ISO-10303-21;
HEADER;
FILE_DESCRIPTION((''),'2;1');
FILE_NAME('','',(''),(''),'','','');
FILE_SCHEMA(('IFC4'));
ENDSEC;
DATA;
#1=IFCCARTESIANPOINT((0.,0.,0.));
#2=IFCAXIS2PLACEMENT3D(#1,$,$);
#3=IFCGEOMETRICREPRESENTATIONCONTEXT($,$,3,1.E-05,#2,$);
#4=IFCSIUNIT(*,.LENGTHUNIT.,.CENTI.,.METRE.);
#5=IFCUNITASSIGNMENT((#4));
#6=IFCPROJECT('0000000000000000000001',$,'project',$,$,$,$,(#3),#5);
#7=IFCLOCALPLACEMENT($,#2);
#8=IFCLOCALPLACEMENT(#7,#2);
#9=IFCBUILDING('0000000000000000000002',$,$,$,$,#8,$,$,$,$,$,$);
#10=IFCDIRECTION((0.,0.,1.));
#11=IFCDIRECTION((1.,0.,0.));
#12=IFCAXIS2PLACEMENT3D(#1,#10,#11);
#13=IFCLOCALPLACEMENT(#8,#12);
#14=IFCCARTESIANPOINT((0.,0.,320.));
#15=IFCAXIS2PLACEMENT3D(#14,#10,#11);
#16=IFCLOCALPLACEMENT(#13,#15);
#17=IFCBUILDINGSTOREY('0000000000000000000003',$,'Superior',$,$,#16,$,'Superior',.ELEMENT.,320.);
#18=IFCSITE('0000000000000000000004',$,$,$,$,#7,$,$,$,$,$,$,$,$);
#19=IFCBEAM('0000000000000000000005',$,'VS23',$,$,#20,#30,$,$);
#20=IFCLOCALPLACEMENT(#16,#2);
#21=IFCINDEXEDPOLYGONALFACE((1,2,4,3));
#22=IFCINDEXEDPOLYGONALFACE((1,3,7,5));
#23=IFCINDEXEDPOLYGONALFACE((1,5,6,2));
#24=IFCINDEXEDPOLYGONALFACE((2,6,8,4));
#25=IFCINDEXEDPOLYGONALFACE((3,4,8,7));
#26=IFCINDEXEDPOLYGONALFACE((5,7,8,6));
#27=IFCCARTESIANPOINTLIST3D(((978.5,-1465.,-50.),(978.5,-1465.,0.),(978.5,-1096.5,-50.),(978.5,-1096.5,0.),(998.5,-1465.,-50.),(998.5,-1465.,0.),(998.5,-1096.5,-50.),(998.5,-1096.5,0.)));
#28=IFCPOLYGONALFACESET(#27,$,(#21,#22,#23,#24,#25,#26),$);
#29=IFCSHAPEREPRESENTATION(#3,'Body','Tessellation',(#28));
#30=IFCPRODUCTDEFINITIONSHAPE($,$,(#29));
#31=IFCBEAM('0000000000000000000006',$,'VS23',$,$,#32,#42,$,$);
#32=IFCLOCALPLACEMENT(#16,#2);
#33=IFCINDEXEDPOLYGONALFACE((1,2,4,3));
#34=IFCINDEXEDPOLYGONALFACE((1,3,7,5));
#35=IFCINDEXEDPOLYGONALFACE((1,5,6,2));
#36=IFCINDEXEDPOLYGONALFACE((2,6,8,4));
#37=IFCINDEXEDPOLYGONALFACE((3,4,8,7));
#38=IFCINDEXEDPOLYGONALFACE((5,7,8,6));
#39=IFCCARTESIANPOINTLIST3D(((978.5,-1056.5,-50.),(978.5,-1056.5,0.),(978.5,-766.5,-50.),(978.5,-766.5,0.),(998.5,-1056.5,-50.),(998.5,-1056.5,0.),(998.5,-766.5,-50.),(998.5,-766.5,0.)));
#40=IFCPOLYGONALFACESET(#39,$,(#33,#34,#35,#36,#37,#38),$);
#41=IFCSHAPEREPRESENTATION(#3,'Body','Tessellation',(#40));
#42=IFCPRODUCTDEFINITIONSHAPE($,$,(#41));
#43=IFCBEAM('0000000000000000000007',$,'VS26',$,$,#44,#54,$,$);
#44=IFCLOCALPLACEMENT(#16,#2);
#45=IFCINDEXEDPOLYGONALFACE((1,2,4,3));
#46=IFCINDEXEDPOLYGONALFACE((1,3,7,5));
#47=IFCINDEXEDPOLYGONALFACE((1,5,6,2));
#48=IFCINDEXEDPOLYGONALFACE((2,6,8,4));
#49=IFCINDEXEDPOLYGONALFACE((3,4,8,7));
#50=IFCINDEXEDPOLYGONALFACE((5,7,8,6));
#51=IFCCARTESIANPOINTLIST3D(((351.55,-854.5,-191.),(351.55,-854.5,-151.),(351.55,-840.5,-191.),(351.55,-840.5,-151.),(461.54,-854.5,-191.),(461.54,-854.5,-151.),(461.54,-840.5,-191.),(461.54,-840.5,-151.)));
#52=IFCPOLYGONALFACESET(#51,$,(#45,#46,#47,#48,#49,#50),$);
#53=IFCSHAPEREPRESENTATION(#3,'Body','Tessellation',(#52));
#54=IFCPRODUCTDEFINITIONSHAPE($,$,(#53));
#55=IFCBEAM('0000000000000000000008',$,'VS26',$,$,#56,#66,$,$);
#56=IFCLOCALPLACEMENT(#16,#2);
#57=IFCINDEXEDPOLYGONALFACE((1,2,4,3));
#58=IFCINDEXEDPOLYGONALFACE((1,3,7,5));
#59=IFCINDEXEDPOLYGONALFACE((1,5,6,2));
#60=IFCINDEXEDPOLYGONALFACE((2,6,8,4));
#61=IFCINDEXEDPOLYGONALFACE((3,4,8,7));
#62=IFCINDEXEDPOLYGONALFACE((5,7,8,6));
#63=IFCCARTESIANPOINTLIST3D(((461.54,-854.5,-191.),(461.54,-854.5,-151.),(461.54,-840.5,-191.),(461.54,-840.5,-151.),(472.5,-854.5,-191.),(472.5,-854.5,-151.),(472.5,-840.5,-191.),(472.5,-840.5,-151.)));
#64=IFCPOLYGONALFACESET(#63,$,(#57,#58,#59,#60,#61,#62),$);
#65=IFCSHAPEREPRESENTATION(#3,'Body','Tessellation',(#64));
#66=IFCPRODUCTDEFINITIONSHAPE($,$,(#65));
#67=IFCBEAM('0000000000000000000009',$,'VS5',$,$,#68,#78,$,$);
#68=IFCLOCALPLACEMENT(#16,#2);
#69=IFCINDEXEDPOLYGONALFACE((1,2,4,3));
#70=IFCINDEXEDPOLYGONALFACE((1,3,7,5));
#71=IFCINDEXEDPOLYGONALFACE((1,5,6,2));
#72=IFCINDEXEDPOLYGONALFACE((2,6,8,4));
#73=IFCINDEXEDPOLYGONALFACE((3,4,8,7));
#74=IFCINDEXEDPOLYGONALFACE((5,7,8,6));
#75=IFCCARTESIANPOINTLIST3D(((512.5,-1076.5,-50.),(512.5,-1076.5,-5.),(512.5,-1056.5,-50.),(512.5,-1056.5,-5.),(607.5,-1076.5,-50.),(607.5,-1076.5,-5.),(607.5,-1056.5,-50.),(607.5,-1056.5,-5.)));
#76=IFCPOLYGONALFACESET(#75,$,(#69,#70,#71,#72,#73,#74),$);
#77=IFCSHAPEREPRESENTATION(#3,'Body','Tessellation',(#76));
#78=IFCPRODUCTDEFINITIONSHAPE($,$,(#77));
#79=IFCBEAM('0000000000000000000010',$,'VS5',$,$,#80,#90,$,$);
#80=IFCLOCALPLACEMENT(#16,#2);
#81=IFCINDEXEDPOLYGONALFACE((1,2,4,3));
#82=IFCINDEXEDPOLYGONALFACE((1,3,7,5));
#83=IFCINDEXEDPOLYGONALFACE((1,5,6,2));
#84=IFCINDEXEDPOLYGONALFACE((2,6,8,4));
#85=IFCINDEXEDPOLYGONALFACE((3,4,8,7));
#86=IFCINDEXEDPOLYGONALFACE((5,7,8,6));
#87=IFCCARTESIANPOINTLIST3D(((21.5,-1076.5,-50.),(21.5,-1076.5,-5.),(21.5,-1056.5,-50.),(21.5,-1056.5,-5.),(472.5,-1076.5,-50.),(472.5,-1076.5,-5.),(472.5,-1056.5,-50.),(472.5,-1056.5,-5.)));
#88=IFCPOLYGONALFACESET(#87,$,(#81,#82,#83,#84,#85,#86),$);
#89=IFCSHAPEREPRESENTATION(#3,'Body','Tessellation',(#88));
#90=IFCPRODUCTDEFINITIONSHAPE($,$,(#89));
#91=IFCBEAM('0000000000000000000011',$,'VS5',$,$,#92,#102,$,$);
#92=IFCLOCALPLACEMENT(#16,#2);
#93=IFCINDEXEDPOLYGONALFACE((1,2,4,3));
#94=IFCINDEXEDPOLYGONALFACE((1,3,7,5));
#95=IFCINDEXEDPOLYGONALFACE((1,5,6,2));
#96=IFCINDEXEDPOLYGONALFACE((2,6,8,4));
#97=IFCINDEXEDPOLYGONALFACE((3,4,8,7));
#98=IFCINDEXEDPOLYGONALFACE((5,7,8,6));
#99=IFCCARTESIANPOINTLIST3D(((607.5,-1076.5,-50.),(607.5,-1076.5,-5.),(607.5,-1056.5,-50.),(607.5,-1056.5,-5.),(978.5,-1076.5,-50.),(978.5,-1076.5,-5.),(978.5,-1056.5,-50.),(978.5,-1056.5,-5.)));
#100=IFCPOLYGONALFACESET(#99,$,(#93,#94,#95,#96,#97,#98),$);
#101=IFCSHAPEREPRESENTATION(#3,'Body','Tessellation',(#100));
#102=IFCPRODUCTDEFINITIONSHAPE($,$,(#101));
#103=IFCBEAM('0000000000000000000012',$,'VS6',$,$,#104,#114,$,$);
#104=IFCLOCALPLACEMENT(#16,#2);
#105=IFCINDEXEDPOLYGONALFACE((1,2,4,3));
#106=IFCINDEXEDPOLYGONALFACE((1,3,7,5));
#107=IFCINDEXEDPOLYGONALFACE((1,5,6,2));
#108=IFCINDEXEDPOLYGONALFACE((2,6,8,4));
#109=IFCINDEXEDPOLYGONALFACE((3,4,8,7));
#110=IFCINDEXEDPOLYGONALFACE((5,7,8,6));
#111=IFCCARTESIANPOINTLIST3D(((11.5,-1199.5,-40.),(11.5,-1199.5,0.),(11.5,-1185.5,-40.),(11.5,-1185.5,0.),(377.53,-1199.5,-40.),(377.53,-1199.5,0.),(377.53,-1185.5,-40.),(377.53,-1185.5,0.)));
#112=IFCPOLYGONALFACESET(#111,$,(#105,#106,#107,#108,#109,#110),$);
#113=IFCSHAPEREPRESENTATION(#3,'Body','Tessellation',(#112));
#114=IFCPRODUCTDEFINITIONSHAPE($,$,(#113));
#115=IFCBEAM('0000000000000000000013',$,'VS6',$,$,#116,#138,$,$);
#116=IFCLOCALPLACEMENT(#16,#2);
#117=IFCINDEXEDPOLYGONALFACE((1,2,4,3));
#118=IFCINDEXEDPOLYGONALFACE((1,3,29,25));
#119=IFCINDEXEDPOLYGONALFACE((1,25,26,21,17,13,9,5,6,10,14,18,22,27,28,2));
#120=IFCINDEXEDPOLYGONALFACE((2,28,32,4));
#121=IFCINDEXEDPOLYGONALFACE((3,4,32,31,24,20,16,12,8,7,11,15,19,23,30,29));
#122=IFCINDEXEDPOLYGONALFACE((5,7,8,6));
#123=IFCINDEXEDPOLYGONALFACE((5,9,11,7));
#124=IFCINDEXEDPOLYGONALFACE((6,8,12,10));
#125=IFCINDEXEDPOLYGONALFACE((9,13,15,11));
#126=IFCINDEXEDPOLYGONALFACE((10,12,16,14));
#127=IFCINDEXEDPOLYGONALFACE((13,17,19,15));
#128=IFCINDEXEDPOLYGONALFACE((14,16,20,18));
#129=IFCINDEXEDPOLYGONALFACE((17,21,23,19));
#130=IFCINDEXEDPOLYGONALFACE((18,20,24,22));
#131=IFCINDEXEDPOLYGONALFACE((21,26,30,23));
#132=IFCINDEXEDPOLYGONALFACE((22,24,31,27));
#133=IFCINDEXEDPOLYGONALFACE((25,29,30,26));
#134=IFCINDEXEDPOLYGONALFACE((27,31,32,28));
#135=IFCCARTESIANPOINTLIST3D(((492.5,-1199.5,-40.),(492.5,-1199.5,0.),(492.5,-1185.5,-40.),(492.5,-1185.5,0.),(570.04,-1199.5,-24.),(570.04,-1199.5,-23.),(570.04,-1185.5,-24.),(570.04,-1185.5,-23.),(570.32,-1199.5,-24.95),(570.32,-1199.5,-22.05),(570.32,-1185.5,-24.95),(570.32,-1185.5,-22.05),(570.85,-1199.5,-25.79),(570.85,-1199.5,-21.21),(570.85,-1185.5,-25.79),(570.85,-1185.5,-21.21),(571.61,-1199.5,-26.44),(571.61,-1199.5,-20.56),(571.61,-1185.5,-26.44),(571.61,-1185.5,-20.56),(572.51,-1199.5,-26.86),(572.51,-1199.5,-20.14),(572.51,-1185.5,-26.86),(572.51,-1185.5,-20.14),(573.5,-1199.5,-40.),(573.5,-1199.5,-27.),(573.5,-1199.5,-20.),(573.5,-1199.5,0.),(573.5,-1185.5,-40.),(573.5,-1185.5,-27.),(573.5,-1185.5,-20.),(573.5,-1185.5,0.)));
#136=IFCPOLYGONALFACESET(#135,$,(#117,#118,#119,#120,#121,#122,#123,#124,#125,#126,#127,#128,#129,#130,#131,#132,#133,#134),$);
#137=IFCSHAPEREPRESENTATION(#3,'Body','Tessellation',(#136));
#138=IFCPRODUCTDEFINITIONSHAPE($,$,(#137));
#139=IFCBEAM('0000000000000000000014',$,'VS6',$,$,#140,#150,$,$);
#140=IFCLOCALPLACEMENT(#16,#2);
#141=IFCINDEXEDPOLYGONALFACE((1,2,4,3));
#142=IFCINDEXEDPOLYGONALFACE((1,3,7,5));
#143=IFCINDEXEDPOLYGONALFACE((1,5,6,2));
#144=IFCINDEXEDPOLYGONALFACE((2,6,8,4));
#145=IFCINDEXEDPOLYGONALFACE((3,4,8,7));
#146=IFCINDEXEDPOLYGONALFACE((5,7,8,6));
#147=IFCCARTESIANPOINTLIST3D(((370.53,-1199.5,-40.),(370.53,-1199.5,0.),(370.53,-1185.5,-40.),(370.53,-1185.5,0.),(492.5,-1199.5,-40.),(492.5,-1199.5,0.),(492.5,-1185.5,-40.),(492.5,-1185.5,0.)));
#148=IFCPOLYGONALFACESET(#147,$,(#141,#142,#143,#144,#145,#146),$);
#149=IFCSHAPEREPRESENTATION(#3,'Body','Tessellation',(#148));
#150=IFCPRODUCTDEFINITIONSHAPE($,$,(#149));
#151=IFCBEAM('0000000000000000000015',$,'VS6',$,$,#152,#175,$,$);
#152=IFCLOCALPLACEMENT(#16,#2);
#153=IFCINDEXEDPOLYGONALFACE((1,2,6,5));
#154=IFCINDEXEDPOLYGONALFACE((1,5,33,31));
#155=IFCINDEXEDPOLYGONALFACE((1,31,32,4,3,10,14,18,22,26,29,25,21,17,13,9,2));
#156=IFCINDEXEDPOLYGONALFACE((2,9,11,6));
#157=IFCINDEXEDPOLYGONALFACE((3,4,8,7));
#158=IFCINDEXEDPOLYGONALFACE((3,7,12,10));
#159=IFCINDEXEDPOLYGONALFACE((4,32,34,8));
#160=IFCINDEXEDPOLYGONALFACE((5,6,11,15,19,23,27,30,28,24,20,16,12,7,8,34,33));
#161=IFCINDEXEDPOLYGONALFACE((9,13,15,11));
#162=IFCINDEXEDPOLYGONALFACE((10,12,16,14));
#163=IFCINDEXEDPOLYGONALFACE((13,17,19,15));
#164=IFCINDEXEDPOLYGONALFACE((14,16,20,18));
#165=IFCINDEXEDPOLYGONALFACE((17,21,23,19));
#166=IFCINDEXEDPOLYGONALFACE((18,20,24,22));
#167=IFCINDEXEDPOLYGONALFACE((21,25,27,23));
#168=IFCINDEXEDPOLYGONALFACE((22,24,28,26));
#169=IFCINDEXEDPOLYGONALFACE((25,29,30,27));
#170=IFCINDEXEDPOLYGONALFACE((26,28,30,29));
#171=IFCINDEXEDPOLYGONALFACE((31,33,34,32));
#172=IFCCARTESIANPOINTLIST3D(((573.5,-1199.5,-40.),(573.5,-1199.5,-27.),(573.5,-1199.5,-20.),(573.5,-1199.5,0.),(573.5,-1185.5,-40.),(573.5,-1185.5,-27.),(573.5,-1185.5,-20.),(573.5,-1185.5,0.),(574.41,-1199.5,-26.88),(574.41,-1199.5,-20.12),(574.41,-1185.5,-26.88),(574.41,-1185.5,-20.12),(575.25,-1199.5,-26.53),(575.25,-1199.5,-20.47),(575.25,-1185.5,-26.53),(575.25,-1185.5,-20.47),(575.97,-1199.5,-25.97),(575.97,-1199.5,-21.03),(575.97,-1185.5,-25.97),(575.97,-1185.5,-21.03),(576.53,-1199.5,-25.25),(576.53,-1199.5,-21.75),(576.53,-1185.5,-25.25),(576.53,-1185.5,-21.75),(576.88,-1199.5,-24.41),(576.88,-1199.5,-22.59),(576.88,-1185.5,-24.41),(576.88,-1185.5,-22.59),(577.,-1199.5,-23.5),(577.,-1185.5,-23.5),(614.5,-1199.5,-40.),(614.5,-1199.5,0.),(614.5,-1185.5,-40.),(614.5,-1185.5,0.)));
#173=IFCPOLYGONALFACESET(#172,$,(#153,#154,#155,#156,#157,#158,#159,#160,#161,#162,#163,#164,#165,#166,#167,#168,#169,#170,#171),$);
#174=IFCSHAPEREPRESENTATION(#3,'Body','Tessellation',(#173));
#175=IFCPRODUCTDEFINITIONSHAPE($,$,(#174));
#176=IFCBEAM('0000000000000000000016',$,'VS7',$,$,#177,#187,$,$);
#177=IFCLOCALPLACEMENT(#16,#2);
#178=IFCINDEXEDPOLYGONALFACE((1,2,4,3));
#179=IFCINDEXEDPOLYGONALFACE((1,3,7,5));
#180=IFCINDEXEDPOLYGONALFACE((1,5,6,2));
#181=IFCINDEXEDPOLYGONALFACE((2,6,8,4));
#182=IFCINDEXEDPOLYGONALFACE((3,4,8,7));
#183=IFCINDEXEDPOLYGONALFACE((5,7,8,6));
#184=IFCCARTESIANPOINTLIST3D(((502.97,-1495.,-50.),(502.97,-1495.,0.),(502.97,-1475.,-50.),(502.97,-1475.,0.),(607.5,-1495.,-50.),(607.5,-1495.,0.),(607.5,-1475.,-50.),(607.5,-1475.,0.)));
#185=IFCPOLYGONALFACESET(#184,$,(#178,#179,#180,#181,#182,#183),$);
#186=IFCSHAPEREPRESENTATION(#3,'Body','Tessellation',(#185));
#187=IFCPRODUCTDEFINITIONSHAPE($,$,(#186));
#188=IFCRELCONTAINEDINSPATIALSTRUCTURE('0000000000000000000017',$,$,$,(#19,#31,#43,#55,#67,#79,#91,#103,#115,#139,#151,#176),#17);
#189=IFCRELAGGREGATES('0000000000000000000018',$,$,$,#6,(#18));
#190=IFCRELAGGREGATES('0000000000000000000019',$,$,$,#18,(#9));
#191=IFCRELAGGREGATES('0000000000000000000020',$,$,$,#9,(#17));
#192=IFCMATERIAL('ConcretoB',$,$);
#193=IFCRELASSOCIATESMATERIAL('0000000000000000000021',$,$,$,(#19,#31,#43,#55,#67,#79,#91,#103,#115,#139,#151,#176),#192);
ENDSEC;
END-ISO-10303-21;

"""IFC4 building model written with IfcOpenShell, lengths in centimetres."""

from ifc_helpers import new_model, si_unit, frame, origin, origin_with_axes, origin_2d_with_axis, place, context, project, spatial, polyline, circle, outline, extrude, material, element, save


model = new_model("IFC4")

# Units and contexts
context_of_model = context(None, 3, precision=1e-05, world=origin())
ifc_project = project(units=[si_unit("LENGTHUNIT", "METRE", prefix="CENTI")], contexts=[context_of_model])

# Site, building, storey
site_placement = place(None, origin())
site = spatial("IfcSite", under=ifc_project, at=site_placement)
building_placement = place(site_placement, origin())
building = spatial("IfcBuilding", under=site, at=building_placement)
placement = place(building_placement, origin_with_axes())
storey_placement = place(placement, frame((0.0, 0.0, 320.0), z_axis=(0.0, 0.0, 1.0), x_axis=(1.0, 0.0, 0.0)))
storey = spatial("IfcBuildingStorey", under=building, at=storey_placement, Name="Superior", LongName="Superior", CompositionType="ELEMENT", Elevation=320.0)

# Shared definitions
ifc_material = material(Name="ConcretoB")

# Beams
beam_1_placement = place(storey_placement, frame((988.5, -1280.75, 0.0), z_axis=(0.0, 0.0, 1.0), x_axis=(1.0, 0.0, 0.0)))
element("IfcBeam", 1, at=beam_1_placement, inside=storey, material=ifc_material, Name="VS23", context=context_of_model, shape_type="SolidModel", body=[
    extrude(outline(polyline([(-10.0, -25.0), (10.0, -25.0), (10.0, 25.0), (-10.0, 25.0), (-10.0, -25.0)])), frame((0.0, -184.25, -25.0), z_axis=(0.0, 1.0, 0.0), x_axis=(1.0, 0.0, 0.0)), (0.0, 0.0, 1.0), 368.5),
])
beam_2_placement = place(storey_placement, frame((988.5, -911.5, 0.0), z_axis=(0.0, 0.0, 1.0), x_axis=(1.0, 0.0, 0.0)))
element("IfcBeam", 2, at=beam_2_placement, inside=storey, material=ifc_material, Name="VS23", context=context_of_model, shape_type="SolidModel", body=[
    extrude(outline(polyline([(-10.0, -25.0), (10.0, -25.0), (10.0, 25.0), (-10.0, 25.0), (-10.0, -25.0)])), frame((0.0, -145.0, -25.0), z_axis=(0.0, 1.0, 0.0), x_axis=(1.0, 0.0, 0.0)), (0.0, 0.0, 1.0), 290.0),
])
beam_3_placement = place(storey_placement, frame((406.55, -847.5, -151.0), z_axis=(0.0, 0.0, 1.0), x_axis=(1.0, 0.0, 0.0)))
element("IfcBeam", 3, at=beam_3_placement, inside=storey, material=ifc_material, Name="VS26", context=context_of_model, shape_type="SolidModel", body=[
    extrude(outline(polyline([(-7.0, -20.0), (7.0, -20.0), (7.0, 20.0), (-7.0, 20.0), (-7.0, -20.0)])), frame((-54.99, 0.0, -20.0), z_axis=(1.0, 0.0, 0.0), x_axis=(0.0, -1.0, 0.0)), (0.0, 0.0, 1.0), 109.99),
])
beam_4_placement = place(storey_placement, frame((467.02, -847.5, -151.0), z_axis=(0.0, 0.0, 1.0), x_axis=(1.0, 0.0, 0.0)))
element("IfcBeam", 4, at=beam_4_placement, inside=storey, material=ifc_material, Name="VS26", context=context_of_model, shape_type="SolidModel", body=[
    extrude(outline(polyline([(-7.0, -20.0), (7.0, -20.0), (7.0, 20.0), (-7.0, 20.0), (-7.0, -20.0)])), frame((-5.48, 0.0, -20.0), z_axis=(1.0, 0.0, 0.0), x_axis=(0.0, -1.0, 0.0)), (0.0, 0.0, 1.0), 10.96),
])
beam_5_placement = place(storey_placement, frame((560.0, -1066.5, -5.0), z_axis=(0.0, 0.0, 1.0), x_axis=(1.0, 0.0, 0.0)))
element("IfcBeam", 5, at=beam_5_placement, inside=storey, material=ifc_material, Name="VS5", context=context_of_model, shape_type="SolidModel", body=[
    extrude(outline(polyline([(-10.0, -22.5), (10.0, -22.5), (10.0, 22.5), (-10.0, 22.5), (-10.0, -22.5)])), frame((-47.5, 0.0, -22.5), z_axis=(1.0, 0.0, 0.0), x_axis=(0.0, -1.0, 0.0)), (0.0, 0.0, 1.0), 95.0),
])
beam_6_placement = place(storey_placement, frame((247.0, -1066.5, -5.0), z_axis=(0.0, 0.0, 1.0), x_axis=(1.0, 0.0, 0.0)))
element("IfcBeam", 6, at=beam_6_placement, inside=storey, material=ifc_material, Name="VS5", context=context_of_model, shape_type="SolidModel", body=[
    extrude(outline(polyline([(-10.0, -22.5), (10.0, -22.5), (10.0, 22.5), (-10.0, 22.5), (-10.0, -22.5)])), frame((-225.5, 0.0, -22.5), z_axis=(1.0, 0.0, 0.0), x_axis=(0.0, -1.0, 0.0)), (0.0, 0.0, 1.0), 451.0),
])
beam_7_placement = place(storey_placement, frame((793.0, -1066.5, -5.0), z_axis=(0.0, 0.0, 1.0), x_axis=(1.0, 0.0, 0.0)))
element("IfcBeam", 7, at=beam_7_placement, inside=storey, material=ifc_material, Name="VS5", context=context_of_model, shape_type="SolidModel", body=[
    extrude(outline(polyline([(-10.0, -22.5), (10.0, -22.5), (10.0, 22.5), (-10.0, 22.5), (-10.0, -22.5)])), frame((-185.5, 0.0, -22.5), z_axis=(1.0, 0.0, 0.0), x_axis=(0.0, -1.0, 0.0)), (0.0, 0.0, 1.0), 371.0),
])
beam_8_placement = place(storey_placement, frame((194.51, -1192.5, 0.0), z_axis=(0.0, 0.0, 1.0), x_axis=(1.0, 0.0, 0.0)))
element("IfcBeam", 8, at=beam_8_placement, inside=storey, material=ifc_material, Name="VS6", context=context_of_model, shape_type="SolidModel", body=[
    extrude(outline(polyline([(7.0, 20.0), (-7.0, 20.0), (-7.0, -20.0), (7.0, -20.0), (7.0, 20.0)])), frame((183.01, 0.0, -20.0), z_axis=(-1.0, 0.0, 0.0), x_axis=(0.0, -1.0, 0.0)), (0.0, 0.0, 1.0), 366.03),
])

# Beam, opening
beam_9_placement = place(storey_placement, frame((533.0, -1192.5, 0.0), z_axis=(0.0, 0.0, 1.0), x_axis=(1.0, 0.0, 0.0)))
beam_9 = element("IfcBeam", 9, at=beam_9_placement, inside=storey, material=ifc_material, Name="VS6", context=context_of_model, shape_type="SolidModel", body=[
    extrude(outline(polyline([(7.0, 20.0), (-7.0, 20.0), (-7.0, -20.0), (7.0, -20.0), (7.0, 20.0)])), frame((40.5, 0.0, -20.0), z_axis=(-1.0, 0.0, 0.0), x_axis=(0.0, -1.0, 0.0)), (0.0, 0.0, 1.0), 81.0),
])
opening_1_placement = place(storey_placement, frame((0.0, 0.0, -320.0), z_axis=(0.0, 0.0, 1.0), x_axis=(1.0, 0.0, 0.0)))
element("IfcOpeningElement", 10, at=opening_1_placement, cuts=beam_9, material=ifc_material, context=context_of_model, shape_type="SweptSolid", body=[
    extrude(circle(Radius=3.5, at=origin_2d_with_axis()), frame((573.5, -1185.5, 296.5), z_axis=(0.0, -1.0, 0.0), x_axis=(1.0, 0.0, 0.0)), (0.0, 0.0, 1.0), 14.0),
])

# Beam
beam_10_placement = place(storey_placement, frame((431.51, -1192.5, 0.0), z_axis=(0.0, 0.0, 1.0), x_axis=(1.0, 0.0, 0.0)))
element("IfcBeam", 11, at=beam_10_placement, inside=storey, material=ifc_material, Name="VS6", context=context_of_model, shape_type="SolidModel", body=[
    extrude(outline(polyline([(7.0, 20.0), (-7.0, 20.0), (-7.0, -20.0), (7.0, -20.0), (7.0, 20.0)])), frame((60.98, 0.0, -20.0), z_axis=(-1.0, 0.0, 0.0), x_axis=(0.0, -1.0, 0.0)), (0.0, 0.0, 1.0), 121.97),
])

# Beam, opening
beam_11_placement = place(storey_placement, frame((594.0, -1192.5, 0.0), z_axis=(0.0, 0.0, 1.0), x_axis=(1.0, 0.0, 0.0)))
beam_11 = element("IfcBeam", 12, at=beam_11_placement, inside=storey, material=ifc_material, Name="VS6", context=context_of_model, shape_type="SolidModel", body=[
    extrude(outline(polyline([(7.0, 20.0), (-7.0, 20.0), (-7.0, -20.0), (7.0, -20.0), (7.0, 20.0)])), frame((20.5, 0.0, -20.0), z_axis=(-1.0, 0.0, 0.0), x_axis=(0.0, -1.0, 0.0)), (0.0, 0.0, 1.0), 41.0),
])
opening_2_placement = place(storey_placement, frame((0.0, 0.0, -320.0), z_axis=(0.0, 0.0, 1.0), x_axis=(1.0, 0.0, 0.0)))
element("IfcOpeningElement", 13, at=opening_2_placement, cuts=beam_11, material=ifc_material, context=context_of_model, shape_type="SweptSolid", body=[
    extrude(circle(Radius=3.5, at=origin_2d_with_axis()), frame((573.5, -1185.5, 296.5), z_axis=(0.0, -1.0, 0.0), x_axis=(1.0, 0.0, 0.0)), (0.0, 0.0, 1.0), 14.0),
])

# Beam
beam_12_placement = place(storey_placement, frame((555.24, -1485.0, 0.0), z_axis=(0.0, 0.0, 1.0), x_axis=(1.0, 0.0, 0.0)))
element("IfcBeam", 14, at=beam_12_placement, inside=storey, material=ifc_material, Name="VS7", context=context_of_model, shape_type="SolidModel", body=[
    extrude(outline(polyline([(-10.0, -25.0), (10.0, -25.0), (10.0, 25.0), (-10.0, 25.0), (-10.0, -25.0)])), frame((-52.27, 0.0, -25.0), z_axis=(1.0, 0.0, 0.0), x_axis=(0.0, -1.0, 0.0)), (0.0, 0.0, 1.0), 104.53),
])

save(model, "model.ifc")
